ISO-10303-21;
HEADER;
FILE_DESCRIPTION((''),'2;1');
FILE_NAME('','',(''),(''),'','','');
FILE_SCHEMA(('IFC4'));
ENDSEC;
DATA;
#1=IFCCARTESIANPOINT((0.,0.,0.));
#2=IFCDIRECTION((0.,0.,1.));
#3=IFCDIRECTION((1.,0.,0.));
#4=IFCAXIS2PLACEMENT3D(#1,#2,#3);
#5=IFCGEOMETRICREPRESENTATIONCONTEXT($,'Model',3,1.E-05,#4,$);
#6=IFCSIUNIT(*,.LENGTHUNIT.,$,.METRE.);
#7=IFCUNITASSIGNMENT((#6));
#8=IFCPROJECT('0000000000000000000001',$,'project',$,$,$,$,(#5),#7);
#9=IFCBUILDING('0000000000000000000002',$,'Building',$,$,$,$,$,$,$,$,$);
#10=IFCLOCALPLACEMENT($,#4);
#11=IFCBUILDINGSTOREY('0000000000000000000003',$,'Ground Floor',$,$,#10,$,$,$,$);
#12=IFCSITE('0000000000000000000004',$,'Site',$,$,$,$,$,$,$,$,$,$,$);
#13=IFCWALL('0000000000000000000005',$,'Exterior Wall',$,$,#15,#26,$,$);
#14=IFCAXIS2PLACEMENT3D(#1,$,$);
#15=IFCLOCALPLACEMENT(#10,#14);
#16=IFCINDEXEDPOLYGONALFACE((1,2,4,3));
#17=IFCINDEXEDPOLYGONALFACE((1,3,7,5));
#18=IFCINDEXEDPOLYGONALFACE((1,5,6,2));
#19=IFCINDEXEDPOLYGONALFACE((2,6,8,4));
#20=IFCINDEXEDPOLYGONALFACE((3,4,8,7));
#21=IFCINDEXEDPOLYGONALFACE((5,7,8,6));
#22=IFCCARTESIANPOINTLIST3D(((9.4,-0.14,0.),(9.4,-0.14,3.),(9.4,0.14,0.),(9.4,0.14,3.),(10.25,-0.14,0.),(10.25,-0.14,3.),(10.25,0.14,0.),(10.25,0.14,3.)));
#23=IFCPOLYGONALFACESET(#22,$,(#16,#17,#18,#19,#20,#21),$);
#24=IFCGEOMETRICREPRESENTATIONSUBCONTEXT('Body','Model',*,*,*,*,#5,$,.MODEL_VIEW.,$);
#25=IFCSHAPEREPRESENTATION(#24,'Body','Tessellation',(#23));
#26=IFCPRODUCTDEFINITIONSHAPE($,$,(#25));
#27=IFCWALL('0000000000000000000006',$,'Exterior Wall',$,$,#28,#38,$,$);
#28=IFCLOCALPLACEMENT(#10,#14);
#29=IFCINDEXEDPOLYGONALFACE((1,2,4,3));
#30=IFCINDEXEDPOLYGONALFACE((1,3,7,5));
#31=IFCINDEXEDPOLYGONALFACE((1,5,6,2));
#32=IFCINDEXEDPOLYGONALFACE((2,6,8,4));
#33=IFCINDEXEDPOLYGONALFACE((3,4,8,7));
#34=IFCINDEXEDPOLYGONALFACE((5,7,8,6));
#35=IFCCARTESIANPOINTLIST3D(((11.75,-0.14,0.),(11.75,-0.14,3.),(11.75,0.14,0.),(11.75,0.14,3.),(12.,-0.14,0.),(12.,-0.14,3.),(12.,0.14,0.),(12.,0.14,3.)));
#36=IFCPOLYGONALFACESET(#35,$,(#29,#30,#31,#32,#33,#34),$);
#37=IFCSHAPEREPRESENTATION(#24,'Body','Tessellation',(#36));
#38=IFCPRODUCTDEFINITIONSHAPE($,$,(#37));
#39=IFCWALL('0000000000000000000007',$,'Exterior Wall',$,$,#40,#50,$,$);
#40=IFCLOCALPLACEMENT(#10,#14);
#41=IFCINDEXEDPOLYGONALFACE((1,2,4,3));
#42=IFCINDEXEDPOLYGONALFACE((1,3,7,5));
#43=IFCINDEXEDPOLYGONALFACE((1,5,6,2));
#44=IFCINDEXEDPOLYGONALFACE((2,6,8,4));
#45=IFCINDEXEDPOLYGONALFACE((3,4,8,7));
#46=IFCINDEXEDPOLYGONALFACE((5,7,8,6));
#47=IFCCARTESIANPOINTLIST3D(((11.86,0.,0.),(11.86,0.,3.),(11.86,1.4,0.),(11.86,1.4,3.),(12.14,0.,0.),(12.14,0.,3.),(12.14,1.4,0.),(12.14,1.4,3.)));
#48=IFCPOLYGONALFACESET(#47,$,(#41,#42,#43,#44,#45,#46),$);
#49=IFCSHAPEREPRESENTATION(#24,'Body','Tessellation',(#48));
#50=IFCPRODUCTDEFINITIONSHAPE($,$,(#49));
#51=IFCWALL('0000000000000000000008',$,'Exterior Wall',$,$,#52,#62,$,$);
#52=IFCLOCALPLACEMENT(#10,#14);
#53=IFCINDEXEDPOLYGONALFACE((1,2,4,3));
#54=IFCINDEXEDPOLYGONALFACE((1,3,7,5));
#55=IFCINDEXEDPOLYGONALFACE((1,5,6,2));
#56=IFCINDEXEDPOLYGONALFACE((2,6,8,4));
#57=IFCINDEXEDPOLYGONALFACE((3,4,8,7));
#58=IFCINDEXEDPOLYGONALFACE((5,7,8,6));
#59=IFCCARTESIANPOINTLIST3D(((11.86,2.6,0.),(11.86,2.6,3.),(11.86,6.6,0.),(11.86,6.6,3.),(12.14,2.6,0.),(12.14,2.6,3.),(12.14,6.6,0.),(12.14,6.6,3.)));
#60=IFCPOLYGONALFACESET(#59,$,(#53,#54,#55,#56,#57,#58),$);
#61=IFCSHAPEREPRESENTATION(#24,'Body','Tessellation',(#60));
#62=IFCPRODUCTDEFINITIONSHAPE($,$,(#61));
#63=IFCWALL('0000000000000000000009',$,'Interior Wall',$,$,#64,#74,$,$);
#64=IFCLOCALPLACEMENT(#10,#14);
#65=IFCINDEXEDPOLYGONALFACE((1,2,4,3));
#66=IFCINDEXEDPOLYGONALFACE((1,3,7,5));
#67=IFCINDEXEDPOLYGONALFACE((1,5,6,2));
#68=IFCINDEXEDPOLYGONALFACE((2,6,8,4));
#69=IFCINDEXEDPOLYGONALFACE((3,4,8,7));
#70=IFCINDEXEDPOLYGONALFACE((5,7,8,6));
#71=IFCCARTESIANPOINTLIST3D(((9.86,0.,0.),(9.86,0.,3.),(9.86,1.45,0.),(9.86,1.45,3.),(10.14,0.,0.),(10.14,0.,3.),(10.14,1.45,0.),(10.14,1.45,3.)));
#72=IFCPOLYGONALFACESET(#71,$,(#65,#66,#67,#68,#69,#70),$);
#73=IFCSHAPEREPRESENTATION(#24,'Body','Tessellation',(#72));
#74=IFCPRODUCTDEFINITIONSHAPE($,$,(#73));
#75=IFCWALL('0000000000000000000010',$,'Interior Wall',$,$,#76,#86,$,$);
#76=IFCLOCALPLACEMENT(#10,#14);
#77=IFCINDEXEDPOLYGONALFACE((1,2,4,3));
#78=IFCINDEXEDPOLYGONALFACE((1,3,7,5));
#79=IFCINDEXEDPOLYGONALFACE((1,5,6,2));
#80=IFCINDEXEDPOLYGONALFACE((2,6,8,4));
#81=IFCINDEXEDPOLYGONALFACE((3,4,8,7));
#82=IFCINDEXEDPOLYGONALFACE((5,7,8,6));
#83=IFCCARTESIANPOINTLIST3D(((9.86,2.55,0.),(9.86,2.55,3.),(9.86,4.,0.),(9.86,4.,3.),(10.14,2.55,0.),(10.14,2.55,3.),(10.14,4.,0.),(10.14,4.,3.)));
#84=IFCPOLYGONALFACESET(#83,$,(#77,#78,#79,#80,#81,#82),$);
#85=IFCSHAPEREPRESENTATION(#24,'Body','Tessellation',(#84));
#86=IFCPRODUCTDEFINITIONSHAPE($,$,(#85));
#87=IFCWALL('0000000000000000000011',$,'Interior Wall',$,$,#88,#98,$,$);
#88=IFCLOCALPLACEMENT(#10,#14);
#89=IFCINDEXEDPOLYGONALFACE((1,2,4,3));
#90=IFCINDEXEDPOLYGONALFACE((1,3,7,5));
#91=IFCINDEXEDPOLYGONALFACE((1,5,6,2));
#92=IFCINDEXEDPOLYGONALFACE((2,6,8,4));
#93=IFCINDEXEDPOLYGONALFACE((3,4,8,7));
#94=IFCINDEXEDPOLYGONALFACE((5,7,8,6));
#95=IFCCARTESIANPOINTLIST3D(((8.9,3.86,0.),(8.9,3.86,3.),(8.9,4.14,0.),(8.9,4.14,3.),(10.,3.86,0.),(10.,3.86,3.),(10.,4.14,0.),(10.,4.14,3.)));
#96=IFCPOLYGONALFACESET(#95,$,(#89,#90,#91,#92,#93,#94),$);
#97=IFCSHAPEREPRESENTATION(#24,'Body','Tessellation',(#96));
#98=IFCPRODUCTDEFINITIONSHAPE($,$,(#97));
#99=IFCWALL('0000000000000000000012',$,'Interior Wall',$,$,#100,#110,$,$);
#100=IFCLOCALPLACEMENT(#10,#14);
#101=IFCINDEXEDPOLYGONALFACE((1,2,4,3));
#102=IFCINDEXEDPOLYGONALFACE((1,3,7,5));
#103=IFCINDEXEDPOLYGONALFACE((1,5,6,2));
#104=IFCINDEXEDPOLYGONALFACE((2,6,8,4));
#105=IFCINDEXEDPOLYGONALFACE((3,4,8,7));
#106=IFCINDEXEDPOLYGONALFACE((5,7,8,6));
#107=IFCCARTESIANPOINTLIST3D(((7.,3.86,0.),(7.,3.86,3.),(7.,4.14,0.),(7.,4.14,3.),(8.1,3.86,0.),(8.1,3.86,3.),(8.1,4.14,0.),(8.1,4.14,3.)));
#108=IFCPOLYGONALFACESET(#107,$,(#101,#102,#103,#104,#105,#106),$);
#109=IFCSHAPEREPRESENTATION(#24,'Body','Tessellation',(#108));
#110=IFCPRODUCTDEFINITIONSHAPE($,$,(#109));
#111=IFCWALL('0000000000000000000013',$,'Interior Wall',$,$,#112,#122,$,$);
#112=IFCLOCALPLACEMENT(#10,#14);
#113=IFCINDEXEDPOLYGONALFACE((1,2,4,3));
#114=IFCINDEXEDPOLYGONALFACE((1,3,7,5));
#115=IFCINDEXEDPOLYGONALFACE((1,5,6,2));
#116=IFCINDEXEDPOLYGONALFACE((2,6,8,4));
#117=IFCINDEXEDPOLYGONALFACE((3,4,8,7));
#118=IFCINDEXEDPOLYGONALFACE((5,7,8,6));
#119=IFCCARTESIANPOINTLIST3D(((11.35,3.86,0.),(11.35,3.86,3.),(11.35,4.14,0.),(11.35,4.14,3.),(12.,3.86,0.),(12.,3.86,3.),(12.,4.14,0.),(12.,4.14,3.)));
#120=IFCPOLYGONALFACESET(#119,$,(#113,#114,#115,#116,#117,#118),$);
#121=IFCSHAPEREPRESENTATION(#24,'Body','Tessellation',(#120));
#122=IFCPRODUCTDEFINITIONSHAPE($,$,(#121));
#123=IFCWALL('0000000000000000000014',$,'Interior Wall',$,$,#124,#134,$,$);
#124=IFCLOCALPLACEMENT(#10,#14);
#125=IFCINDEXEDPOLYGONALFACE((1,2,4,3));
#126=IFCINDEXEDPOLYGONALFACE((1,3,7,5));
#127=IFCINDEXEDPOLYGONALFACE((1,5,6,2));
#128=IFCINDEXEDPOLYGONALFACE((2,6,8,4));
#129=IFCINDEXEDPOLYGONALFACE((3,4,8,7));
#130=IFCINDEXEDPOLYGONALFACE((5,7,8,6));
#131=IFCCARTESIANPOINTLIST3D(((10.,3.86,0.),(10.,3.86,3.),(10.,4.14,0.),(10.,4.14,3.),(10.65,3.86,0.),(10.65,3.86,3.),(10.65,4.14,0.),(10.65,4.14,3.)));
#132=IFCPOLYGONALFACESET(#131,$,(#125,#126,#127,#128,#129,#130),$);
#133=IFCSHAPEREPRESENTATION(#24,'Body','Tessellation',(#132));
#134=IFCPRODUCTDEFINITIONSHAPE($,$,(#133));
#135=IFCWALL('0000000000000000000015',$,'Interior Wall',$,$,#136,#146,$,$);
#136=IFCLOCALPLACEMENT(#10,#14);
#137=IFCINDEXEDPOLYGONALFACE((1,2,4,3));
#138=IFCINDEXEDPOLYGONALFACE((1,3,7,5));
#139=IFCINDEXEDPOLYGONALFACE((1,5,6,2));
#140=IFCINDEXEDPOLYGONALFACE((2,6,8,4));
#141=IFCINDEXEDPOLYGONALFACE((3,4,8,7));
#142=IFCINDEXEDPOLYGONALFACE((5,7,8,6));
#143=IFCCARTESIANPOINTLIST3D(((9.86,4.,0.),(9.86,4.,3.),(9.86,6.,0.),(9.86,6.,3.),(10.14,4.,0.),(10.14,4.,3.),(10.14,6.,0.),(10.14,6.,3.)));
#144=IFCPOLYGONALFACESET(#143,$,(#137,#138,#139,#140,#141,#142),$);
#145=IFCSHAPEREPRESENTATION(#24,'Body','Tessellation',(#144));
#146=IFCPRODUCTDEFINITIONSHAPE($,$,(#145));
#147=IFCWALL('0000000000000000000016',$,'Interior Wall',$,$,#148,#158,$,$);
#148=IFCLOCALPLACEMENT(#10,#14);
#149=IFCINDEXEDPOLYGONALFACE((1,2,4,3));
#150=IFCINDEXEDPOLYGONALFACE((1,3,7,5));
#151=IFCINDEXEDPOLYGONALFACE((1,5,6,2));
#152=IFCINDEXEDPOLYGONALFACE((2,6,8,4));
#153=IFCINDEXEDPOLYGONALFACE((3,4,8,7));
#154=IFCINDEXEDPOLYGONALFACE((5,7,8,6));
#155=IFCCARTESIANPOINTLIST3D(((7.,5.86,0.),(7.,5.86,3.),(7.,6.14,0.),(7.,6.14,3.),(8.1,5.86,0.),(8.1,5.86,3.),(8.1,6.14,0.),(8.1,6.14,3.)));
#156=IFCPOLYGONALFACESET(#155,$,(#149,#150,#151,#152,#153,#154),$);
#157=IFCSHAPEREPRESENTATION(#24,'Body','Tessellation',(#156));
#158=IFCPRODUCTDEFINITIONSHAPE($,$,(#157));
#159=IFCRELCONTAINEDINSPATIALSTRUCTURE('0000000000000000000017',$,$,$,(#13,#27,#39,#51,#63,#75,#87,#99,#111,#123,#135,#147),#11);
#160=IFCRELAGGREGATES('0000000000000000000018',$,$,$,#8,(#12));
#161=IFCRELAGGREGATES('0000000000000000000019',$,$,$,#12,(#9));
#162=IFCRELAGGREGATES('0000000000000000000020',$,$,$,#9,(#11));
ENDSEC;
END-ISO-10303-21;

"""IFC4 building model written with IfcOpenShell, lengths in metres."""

from ifc_helpers import new_model, si_unit, frame, origin_with_axes, place, context, subcontext, project, spatial, indexed_curve, outline, extrude, element, save


model = new_model("IFC4")

# Units and contexts
model_context = context("Model", 3, precision=1e-05, world=origin_with_axes())
body_context = subcontext(model_context, "Body", "Model", "MODEL_VIEW")
ifc_project = project(units=[si_unit("LENGTHUNIT", "METRE")], contexts=[model_context])

# Site, building, storey
site = spatial("IfcSite", under=ifc_project, Name="Site")
building = spatial("IfcBuilding", under=site, Name="Building")
storey_placement = place(None, origin_with_axes())
storey = spatial("IfcBuildingStorey", under=building, at=storey_placement, Name="Ground Floor")

# Walls
wall_1_placement = place(storey_placement, frame((9.4, 0.0, 0.0), z_axis=(0.0, 0.0, 1.0), x_axis=(1.0, 0.0, 0.0)))
element("IfcWall", 1, at=wall_1_placement, inside=storey, Name="Exterior Wall", context=body_context, shape_type="SweptSolid", body=[
    extrude(outline(indexed_curve([(0.0, 0.0), (0.0, 0.28), (0.85, 0.28), (0.85, 0.0), (0.0, 0.0)], self_intersect=False)), frame((0.0, -0.14, 0.0), z_axis=(0.0, 0.0, 1.0), x_axis=(1.0, 0.0, 0.0)), (0.0, 0.0, 1.0), 3.0),
])
wall_2_placement = place(storey_placement, frame((11.75, 0.0, 0.0), z_axis=(0.0, 0.0, 1.0), x_axis=(1.0, 0.0, 0.0)))
element("IfcWall", 2, at=wall_2_placement, inside=storey, Name="Exterior Wall", context=body_context, shape_type="SweptSolid", body=[
    extrude(outline(indexed_curve([(0.0, 0.0), (0.0, 0.28), (0.25, 0.28), (0.25, 0.0), (0.0, 0.0)], self_intersect=False)), frame((0.0, -0.14, 0.0), z_axis=(0.0, 0.0, 1.0), x_axis=(1.0, 0.0, 0.0)), (0.0, 0.0, 1.0), 3.0),
])
wall_3_placement = place(storey_placement, frame((12.0, 0.0, 0.0), z_axis=(0.0, 0.0, 1.0), x_axis=(0.0, 1.0, 0.0)))
element("IfcWall", 3, at=wall_3_placement, inside=storey, Name="Exterior Wall", context=body_context, shape_type="SweptSolid", body=[
    extrude(outline(indexed_curve([(0.0, 0.0), (0.0, 0.28), (1.4, 0.28), (1.4, 0.0), (0.0, 0.0)], self_intersect=False)), frame((0.0, -0.14, 0.0), z_axis=(0.0, 0.0, 1.0), x_axis=(1.0, 0.0, 0.0)), (0.0, 0.0, 1.0), 3.0),
])
wall_4_placement = place(storey_placement, frame((12.0, 2.6, 0.0), z_axis=(0.0, 0.0, 1.0), x_axis=(0.0, 1.0, 0.0)))
element("IfcWall", 4, at=wall_4_placement, inside=storey, Name="Exterior Wall", context=body_context, shape_type="SweptSolid", body=[
    extrude(outline(indexed_curve([(0.0, 0.0), (0.0, 0.28), (4.0, 0.28), (4.0, 0.0), (0.0, 0.0)], self_intersect=False)), frame((0.0, -0.14, 0.0), z_axis=(0.0, 0.0, 1.0), x_axis=(1.0, 0.0, 0.0)), (0.0, 0.0, 1.0), 3.0),
])
wall_5_placement = place(storey_placement, frame((10.0, 0.0, 0.0), z_axis=(0.0, 0.0, 1.0), x_axis=(0.0, 1.0, 0.0)))
element("IfcWall", 5, at=wall_5_placement, inside=storey, Name="Interior Wall", context=body_context, shape_type="SweptSolid", body=[
    extrude(outline(indexed_curve([(0.0, 0.0), (0.0, 0.28), (1.45, 0.28), (1.45, 0.0), (0.0, 0.0)], self_intersect=False)), frame((0.0, -0.14, 0.0), z_axis=(0.0, 0.0, 1.0), x_axis=(1.0, 0.0, 0.0)), (0.0, 0.0, 1.0), 3.0),
])
wall_6_placement = place(storey_placement, frame((10.0, 2.55, 0.0), z_axis=(0.0, 0.0, 1.0), x_axis=(0.0, 1.0, 0.0)))
element("IfcWall", 6, at=wall_6_placement, inside=storey, Name="Interior Wall", context=body_context, shape_type="SweptSolid", body=[
    extrude(outline(indexed_curve([(0.0, 0.0), (0.0, 0.28), (1.45, 0.28), (1.45, 0.0), (0.0, 0.0)], self_intersect=False)), frame((0.0, -0.14, 0.0), z_axis=(0.0, 0.0, 1.0), x_axis=(1.0, 0.0, 0.0)), (0.0, 0.0, 1.0), 3.0),
])
for number, where, z_axis, x_axis, name in (
    (7, (10.0, 4.0, 0.0), (0.0, 0.0, 1.0), (-1.0, 0.0, 0.0), "Interior Wall"),
    (8, (8.1, 4.0, 0.0), (0.0, 0.0, 1.0), (-1.0, 0.0, 0.0), "Interior Wall"),
):
    element("IfcWall", number, at=place(storey_placement, frame(where, z_axis=z_axis, x_axis=x_axis)), inside=storey, Name=name, context=body_context, shape_type="SweptSolid", body=[
        extrude(outline(indexed_curve([(0.0, 0.0), (0.0, 0.28), (1.1, 0.28), (1.1, 0.0), (0.0, 0.0)], self_intersect=False)), frame((0.0, -0.14, 0.0), z_axis=(0.0, 0.0, 1.0), x_axis=(1.0, 0.0, 0.0)), (0.0, 0.0, 1.0), 3.0),
    ])
for number, where, z_axis, x_axis, name in (
    (9, (12.0, 4.0, 0.0), (0.0, 0.0, 1.0), (-1.0, 0.0, 0.0), "Interior Wall"),
    (10, (10.65, 4.0, 0.0), (0.0, 0.0, 1.0), (-1.0, 0.0, 0.0), "Interior Wall"),
):
    element("IfcWall", number, at=place(storey_placement, frame(where, z_axis=z_axis, x_axis=x_axis)), inside=storey, Name=name, context=body_context, shape_type="SweptSolid", body=[
        extrude(outline(indexed_curve([(0.0, 0.0), (0.0, 0.28), (0.65, 0.28), (0.65, 0.0), (0.0, 0.0)], self_intersect=False)), frame((0.0, -0.14, 0.0), z_axis=(0.0, 0.0, 1.0), x_axis=(1.0, 0.0, 0.0)), (0.0, 0.0, 1.0), 3.0),
    ])
wall_7_placement = place(storey_placement, frame((10.0, 6.0, 0.0), z_axis=(0.0, 0.0, 1.0), x_axis=(0.0, -1.0, 0.0)))
element("IfcWall", 11, at=wall_7_placement, inside=storey, Name="Interior Wall", context=body_context, shape_type="SweptSolid", body=[
    extrude(outline(indexed_curve([(0.0, 0.0), (0.0, 0.28), (2.0, 0.28), (2.0, 0.0), (0.0, 0.0)], self_intersect=False)), frame((0.0, -0.14, 0.0), z_axis=(0.0, 0.0, 1.0), x_axis=(1.0, 0.0, 0.0)), (0.0, 0.0, 1.0), 3.0),
])
wall_8_placement = place(storey_placement, frame((8.1, 6.0, 0.0), z_axis=(0.0, 0.0, 1.0), x_axis=(-1.0, 0.0, 0.0)))
element("IfcWall", 12, at=wall_8_placement, inside=storey, Name="Interior Wall", context=body_context, shape_type="SweptSolid", body=[
    extrude(outline(indexed_curve([(0.0, 0.0), (0.0, 0.28), (1.1, 0.28), (1.1, 0.0), (0.0, 0.0)], self_intersect=False)), frame((0.0, -0.14, 0.0), z_axis=(0.0, 0.0, 1.0), x_axis=(1.0, 0.0, 0.0)), (0.0, 0.0, 1.0), 3.0),
])

save(model, "model.ifc")
